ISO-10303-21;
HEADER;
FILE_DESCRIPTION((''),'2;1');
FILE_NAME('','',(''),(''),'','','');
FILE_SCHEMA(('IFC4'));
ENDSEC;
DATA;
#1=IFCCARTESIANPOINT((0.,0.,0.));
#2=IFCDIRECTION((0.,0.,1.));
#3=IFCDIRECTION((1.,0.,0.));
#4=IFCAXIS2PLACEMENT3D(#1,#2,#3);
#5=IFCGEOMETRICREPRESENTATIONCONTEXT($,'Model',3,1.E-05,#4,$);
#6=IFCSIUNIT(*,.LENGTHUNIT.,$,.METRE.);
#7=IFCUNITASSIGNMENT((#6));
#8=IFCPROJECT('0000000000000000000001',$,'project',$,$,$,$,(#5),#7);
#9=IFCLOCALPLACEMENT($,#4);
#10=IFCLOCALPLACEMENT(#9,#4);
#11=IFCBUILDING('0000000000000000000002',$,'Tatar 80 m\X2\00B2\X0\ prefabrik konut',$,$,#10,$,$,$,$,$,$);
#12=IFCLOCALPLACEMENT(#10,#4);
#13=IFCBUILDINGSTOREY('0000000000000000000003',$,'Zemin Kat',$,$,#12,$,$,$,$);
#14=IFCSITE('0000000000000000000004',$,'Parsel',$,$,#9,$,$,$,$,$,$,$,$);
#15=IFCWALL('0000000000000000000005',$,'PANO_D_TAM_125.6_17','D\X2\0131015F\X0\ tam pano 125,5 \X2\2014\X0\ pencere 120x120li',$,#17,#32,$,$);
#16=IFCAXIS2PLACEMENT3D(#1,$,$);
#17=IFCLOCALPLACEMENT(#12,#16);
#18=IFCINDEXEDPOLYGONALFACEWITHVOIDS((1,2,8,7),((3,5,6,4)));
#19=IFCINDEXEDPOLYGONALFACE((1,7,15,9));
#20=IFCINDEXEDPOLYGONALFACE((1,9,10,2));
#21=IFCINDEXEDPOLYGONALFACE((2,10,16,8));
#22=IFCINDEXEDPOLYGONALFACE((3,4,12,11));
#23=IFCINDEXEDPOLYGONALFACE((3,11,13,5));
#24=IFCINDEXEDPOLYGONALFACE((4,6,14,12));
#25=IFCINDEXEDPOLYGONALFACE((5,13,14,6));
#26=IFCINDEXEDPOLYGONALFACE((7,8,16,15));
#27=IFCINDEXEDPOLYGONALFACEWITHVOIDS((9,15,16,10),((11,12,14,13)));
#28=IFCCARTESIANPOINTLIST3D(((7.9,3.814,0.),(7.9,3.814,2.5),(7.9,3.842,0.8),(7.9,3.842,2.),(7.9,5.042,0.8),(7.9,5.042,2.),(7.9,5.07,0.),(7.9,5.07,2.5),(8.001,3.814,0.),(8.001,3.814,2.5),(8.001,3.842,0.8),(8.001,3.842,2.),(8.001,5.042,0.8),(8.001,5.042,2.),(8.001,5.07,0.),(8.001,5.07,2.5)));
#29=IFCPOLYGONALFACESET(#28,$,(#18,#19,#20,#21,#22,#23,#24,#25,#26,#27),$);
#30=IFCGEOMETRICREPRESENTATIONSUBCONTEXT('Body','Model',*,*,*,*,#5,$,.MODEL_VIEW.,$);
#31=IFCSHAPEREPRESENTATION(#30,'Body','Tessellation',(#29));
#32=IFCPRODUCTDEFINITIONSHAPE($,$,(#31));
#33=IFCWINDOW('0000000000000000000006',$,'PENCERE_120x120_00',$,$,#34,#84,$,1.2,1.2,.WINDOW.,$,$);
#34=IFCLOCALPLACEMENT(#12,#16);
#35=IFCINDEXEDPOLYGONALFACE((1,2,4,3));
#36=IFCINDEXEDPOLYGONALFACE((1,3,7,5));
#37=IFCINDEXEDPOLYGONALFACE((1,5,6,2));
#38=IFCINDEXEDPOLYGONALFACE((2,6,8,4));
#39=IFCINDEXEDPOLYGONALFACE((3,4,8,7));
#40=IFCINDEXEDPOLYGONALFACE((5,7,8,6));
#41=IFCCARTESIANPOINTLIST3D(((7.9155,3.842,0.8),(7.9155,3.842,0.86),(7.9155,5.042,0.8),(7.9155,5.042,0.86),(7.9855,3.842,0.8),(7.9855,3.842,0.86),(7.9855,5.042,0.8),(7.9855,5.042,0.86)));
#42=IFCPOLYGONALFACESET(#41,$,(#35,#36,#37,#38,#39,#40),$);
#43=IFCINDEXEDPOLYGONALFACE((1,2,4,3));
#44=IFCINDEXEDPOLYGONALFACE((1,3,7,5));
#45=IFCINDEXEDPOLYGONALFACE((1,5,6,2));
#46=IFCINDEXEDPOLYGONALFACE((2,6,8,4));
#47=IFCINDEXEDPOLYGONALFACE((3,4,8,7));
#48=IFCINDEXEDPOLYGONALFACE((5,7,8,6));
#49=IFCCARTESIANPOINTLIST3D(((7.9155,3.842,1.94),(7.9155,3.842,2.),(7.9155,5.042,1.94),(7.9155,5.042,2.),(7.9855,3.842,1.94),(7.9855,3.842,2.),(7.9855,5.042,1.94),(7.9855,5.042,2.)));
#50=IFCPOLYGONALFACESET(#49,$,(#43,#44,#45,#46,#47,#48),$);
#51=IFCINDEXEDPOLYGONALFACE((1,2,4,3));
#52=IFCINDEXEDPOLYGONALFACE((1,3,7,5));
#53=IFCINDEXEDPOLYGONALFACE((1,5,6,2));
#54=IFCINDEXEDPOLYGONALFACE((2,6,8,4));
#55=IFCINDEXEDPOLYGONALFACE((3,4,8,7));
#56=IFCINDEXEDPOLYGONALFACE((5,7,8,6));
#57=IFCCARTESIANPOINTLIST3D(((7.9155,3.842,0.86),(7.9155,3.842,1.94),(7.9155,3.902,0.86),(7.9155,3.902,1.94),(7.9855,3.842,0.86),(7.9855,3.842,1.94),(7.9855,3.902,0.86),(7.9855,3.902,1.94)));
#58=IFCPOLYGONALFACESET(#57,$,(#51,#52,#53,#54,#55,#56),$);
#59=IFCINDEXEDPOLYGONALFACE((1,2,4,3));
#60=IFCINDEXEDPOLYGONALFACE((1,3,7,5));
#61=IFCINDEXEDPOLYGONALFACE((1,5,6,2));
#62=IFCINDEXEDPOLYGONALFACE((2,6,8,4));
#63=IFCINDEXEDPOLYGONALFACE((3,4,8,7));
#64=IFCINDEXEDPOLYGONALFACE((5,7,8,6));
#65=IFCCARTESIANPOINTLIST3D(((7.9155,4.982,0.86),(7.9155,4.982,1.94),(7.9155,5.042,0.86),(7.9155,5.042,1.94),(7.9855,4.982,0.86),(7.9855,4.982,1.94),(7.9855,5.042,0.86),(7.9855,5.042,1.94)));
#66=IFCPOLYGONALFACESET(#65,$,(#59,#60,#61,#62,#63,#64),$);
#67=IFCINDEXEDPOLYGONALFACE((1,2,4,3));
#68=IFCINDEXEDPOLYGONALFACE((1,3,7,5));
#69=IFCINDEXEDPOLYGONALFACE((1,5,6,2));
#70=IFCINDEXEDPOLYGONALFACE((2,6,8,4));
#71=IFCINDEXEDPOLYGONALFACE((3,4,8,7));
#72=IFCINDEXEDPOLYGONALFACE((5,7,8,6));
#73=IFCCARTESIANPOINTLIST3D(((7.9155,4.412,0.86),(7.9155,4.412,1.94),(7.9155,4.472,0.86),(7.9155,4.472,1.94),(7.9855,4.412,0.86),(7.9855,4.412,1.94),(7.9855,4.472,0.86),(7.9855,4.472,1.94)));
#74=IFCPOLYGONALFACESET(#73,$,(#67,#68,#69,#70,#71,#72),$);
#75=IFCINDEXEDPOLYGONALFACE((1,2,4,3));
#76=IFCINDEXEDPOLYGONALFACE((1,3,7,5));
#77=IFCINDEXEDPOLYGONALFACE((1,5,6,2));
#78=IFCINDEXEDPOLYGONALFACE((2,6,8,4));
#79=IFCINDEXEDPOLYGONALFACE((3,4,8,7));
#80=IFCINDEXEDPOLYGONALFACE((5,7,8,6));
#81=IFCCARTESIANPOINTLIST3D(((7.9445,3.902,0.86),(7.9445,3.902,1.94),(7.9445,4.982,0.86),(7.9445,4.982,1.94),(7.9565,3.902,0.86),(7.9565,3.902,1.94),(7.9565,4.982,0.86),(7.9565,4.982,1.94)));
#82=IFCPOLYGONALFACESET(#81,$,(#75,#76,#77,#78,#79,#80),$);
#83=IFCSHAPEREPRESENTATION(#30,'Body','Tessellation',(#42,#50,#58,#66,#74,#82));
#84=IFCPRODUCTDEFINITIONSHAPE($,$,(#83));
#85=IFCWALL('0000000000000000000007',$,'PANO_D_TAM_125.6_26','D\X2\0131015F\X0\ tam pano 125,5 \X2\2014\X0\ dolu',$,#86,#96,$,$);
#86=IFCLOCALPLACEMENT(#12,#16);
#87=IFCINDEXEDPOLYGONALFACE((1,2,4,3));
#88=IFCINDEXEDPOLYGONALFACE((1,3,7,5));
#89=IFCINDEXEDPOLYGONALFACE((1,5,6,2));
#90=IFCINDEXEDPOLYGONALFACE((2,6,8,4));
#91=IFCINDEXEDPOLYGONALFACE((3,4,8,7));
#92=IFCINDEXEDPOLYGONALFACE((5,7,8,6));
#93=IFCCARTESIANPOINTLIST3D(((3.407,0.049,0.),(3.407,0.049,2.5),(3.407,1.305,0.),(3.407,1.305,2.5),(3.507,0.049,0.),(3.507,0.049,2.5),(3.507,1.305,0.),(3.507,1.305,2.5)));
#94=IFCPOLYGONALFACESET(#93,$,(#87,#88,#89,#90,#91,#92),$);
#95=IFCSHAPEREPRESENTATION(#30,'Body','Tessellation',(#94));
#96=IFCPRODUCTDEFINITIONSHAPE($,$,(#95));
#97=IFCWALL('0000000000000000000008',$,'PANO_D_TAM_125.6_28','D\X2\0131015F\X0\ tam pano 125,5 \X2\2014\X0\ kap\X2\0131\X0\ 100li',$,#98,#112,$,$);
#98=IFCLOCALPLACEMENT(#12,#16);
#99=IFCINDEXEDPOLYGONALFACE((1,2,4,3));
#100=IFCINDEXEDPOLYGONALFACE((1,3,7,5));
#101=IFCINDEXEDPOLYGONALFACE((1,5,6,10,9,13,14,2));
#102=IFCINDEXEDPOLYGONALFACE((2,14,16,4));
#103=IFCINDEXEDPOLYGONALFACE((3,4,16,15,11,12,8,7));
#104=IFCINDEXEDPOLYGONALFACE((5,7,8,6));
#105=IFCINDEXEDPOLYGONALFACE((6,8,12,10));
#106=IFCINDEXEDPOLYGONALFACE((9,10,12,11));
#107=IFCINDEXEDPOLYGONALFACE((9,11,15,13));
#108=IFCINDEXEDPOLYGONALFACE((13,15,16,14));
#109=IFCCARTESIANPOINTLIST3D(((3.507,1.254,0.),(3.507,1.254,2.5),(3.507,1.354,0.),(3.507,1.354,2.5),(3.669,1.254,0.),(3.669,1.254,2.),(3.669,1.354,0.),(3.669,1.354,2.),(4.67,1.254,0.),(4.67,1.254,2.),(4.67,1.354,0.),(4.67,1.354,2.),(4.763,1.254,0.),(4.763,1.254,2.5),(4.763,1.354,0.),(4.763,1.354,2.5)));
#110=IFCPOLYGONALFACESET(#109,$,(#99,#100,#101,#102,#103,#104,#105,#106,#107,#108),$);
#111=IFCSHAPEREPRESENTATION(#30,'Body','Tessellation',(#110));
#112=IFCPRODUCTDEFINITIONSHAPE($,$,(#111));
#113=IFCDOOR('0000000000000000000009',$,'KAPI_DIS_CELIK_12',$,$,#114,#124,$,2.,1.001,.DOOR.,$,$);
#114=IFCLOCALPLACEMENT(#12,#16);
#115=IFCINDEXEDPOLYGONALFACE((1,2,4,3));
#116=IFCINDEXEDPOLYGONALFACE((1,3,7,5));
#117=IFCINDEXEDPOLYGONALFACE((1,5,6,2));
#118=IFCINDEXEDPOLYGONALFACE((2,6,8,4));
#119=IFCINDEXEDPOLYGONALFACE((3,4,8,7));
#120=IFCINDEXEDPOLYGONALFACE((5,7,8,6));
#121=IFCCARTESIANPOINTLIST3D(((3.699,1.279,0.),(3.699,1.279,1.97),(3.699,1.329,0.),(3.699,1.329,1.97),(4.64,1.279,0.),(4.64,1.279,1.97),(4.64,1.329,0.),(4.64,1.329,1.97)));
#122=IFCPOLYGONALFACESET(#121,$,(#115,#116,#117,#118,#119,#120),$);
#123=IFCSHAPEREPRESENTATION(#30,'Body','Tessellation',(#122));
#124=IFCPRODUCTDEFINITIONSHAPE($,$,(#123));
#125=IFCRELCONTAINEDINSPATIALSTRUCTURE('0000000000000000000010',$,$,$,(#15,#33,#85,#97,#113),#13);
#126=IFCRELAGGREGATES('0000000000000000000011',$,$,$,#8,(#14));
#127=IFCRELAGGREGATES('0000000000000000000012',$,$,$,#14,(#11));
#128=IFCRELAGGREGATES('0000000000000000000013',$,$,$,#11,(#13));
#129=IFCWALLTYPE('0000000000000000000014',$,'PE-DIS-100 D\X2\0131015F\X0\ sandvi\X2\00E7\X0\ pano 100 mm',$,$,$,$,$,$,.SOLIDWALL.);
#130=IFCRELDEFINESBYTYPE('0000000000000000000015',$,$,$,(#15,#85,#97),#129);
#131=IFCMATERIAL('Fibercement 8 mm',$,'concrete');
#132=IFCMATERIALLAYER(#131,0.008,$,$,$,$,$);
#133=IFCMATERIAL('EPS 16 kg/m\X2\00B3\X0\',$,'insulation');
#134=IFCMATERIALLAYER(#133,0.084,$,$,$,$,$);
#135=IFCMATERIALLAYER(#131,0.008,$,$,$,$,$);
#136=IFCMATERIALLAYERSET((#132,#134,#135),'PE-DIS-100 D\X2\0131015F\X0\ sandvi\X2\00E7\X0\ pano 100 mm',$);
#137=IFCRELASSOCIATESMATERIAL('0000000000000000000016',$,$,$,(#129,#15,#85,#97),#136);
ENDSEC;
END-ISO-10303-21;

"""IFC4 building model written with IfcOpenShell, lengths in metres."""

from ifc_helpers import new_model, si_unit, frame, origin_with_axes, place, context, subcontext, project, spatial, line, indexed_curve, outline, extrude, material, layer, layer_set, layer_usage, type_object, element, fill, save


model = new_model("IFC4")

# Units and contexts
model_context = context("Model", 3, precision=1e-05, world=origin_with_axes())
body_context = subcontext(model_context, "Body", "Model", "MODEL_VIEW")
ifc_project = project(units=[si_unit("LENGTHUNIT", "METRE")], contexts=[model_context])

# Site, building, storey
site_placement = place(None, origin_with_axes())
site = spatial("IfcSite", under=ifc_project, at=site_placement, Name="Parsel")
building_placement = place(site_placement, origin_with_axes())
building = spatial("IfcBuilding", under=site, at=building_placement, Name="Tatar 80 m² prefabrik konut")
storey_placement = place(building_placement, origin_with_axes())
storey = spatial("IfcBuildingStorey", under=building, at=storey_placement, Name="Zemin Kat")

# Shared definitions
ifc_material_1 = material(Name="Fibercement 8 mm", Category="concrete")
ifc_layer_1 = layer(ifc_material_1, 0.008)
ifc_material_2 = material(Name="EPS 16 kg/m³", Category="insulation")
ifc_layer_2 = layer(ifc_material_2, 0.084)
ifc_layer_3 = layer(ifc_material_1, 0.008)
ifc_layer_set_1 = layer_set([ifc_layer_1, ifc_layer_2, ifc_layer_3], Name="PE-DIS-100 Dış sandviç pano 100 mm")
wall_type_1 = type_object("IfcWallType", Name="PE-DIS-100 Dış sandviç pano 100 mm", PredefinedType="SOLIDWALL", material=ifc_layer_set_1)

# Wall, opening, window
ifc_layer_usage_1 = layer_usage(ifc_layer_set_1, "AXIS2", "POSITIVE", 0.0)
wall_1_placement = place(storey_placement, frame((8.001, 3.814, 0.0), z_axis=(0.0, 0.0, 1.0), x_axis=(0.0, 1.0, 0.0)))
wall_1 = element("IfcWall", 1, at=wall_1_placement, inside=storey, type_object=wall_type_1, material=ifc_layer_usage_1, Name="PANO_D_TAM_125.6_17", Description="Dış tam pano 125,5 — pencere 120x120li", context=body_context, shape_type="SweptSolid", body=[
    extrude(outline(indexed_curve([(0.0, 0.0), (1.256, 0.0), (1.256, 0.101), (0.0, 0.101)], segments=[line(1, 2, 3, 4, 1)])), origin_with_axes(), (0.0, 0.0, 1.0), 2.5),
])
opening_1_placement = place(wall_1_placement, origin_with_axes())
opening_1 = element("IfcOpeningElement", 2, at=opening_1_placement, cuts=wall_1, PredefinedType="OPENING", context=body_context, shape_type="SweptSolid", body=[
    extrude(outline(indexed_curve([(0.0, 0.0), (1.2, 0.0), (1.2, 0.141), (0.0, 0.141)], segments=[line(1, 2, 3, 4, 1)])), frame((0.028, -0.02, 0.8), z_axis=(0.0, 0.0, 1.0), x_axis=(1.0, 0.0, 0.0)), (0.0, 0.0, 1.0), 1.2),
])
window_1_placement = place(storey_placement, frame((8.001, 3.814, 0.0), z_axis=(0.0, 0.0, 1.0), x_axis=(0.0, 1.0, 0.0)))
window_1 = element("IfcWindow", 3, at=window_1_placement, inside=storey, Name="PENCERE_120x120_00", OverallHeight=1.2, OverallWidth=1.2, PredefinedType="WINDOW", context=body_context, shape_type="SweptSolid", body=[
    extrude(outline(indexed_curve([(0.0, 0.0), (1.2, 0.0), (1.2, 0.07), (0.0, 0.07)], segments=[line(1, 2, 3, 4, 1)])), frame((0.028, 0.0155, 0.8), z_axis=(0.0, 0.0, 1.0), x_axis=(1.0, 0.0, 0.0)), (0.0, 0.0, 1.0), 0.06),
    extrude(outline(indexed_curve([(0.0, 0.0), (1.2, 0.0), (1.2, 0.07), (0.0, 0.07)], segments=[line(1, 2, 3, 4, 1)])), frame((0.028, 0.0155, 1.94), z_axis=(0.0, 0.0, 1.0), x_axis=(1.0, 0.0, 0.0)), (0.0, 0.0, 1.0), 0.06),
    extrude(outline(indexed_curve([(0.0, 0.0), (0.06, 0.0), (0.06, 0.07), (0.0, 0.07)], segments=[line(1, 2, 3, 4, 1)])), frame((0.028, 0.0155, 0.86), z_axis=(0.0, 0.0, 1.0), x_axis=(1.0, 0.0, 0.0)), (0.0, 0.0, 1.0), 1.08),
    extrude(outline(indexed_curve([(0.0, 0.0), (0.06, 0.0), (0.06, 0.07), (0.0, 0.07)], segments=[line(1, 2, 3, 4, 1)])), frame((1.168, 0.0155, 0.86), z_axis=(0.0, 0.0, 1.0), x_axis=(1.0, 0.0, 0.0)), (0.0, 0.0, 1.0), 1.08),
    extrude(outline(indexed_curve([(0.0, 0.0), (0.06, 0.0), (0.06, 0.07), (0.0, 0.07)], segments=[line(1, 2, 3, 4, 1)])), frame((0.598, 0.0155, 0.86), z_axis=(0.0, 0.0, 1.0), x_axis=(1.0, 0.0, 0.0)), (0.0, 0.0, 1.0), 1.08),
    extrude(outline(indexed_curve([(0.0, 0.0), (1.08, 0.0), (1.08, 0.012), (0.0, 0.012)], segments=[line(1, 2, 3, 4, 1)])), frame((0.088, 0.0445, 0.86), z_axis=(0.0, 0.0, 1.0), x_axis=(1.0, 0.0, 0.0)), (0.0, 0.0, 1.0), 1.08),
])
fill(opening_1, window_1)

# Wall
ifc_layer_usage_2 = layer_usage(ifc_layer_set_1, "AXIS2", "POSITIVE", 0.0)
wall_2_placement = place(storey_placement, frame((3.507, 0.049, 0.0), z_axis=(0.0, 0.0, 1.0), x_axis=(0.0, 1.0, 0.0)))
element("IfcWall", 4, at=wall_2_placement, inside=storey, type_object=wall_type_1, material=ifc_layer_usage_2, Name="PANO_D_TAM_125.6_26", Description="Dış tam pano 125,5 — dolu", context=body_context, shape_type="SweptSolid", body=[
    extrude(outline(indexed_curve([(0.0, 0.0), (1.256, 0.0), (1.256, 0.1), (0.0, 0.1)], segments=[line(1, 2, 3, 4, 1)])), origin_with_axes(), (0.0, 0.0, 1.0), 2.5),
])

# Wall, opening, door
ifc_layer_usage_3 = layer_usage(ifc_layer_set_1, "AXIS2", "POSITIVE", 0.0)
wall_3_placement = place(storey_placement, frame((3.507, 1.254, 0.0), z_axis=(0.0, 0.0, 1.0), x_axis=(1.0, 0.0, 0.0)))
wall_3 = element("IfcWall", 5, at=wall_3_placement, inside=storey, type_object=wall_type_1, material=ifc_layer_usage_3, Name="PANO_D_TAM_125.6_28", Description="Dış tam pano 125,5 — kapı 100li", context=body_context, shape_type="SweptSolid", body=[
    extrude(outline(indexed_curve([(0.0, 0.0), (1.256, 0.0), (1.256, 0.1), (0.0, 0.1)], segments=[line(1, 2, 3, 4, 1)])), origin_with_axes(), (0.0, 0.0, 1.0), 2.5),
])
opening_2_placement = place(wall_3_placement, origin_with_axes())
opening_2 = element("IfcOpeningElement", 6, at=opening_2_placement, cuts=wall_3, PredefinedType="OPENING", context=body_context, shape_type="SweptSolid", body=[
    extrude(outline(indexed_curve([(0.0, 0.0), (1.001, 0.0), (1.001, 0.14), (0.0, 0.14)], segments=[line(1, 2, 3, 4, 1)])), frame((0.162, -0.02, 0.0), z_axis=(0.0, 0.0, 1.0), x_axis=(1.0, 0.0, 0.0)), (0.0, 0.0, 1.0), 2.0),
])
door_placement = place(storey_placement, frame((3.507, 1.254, 0.0), z_axis=(0.0, 0.0, 1.0), x_axis=(1.0, 0.0, 0.0)))
door = element("IfcDoor", 7, at=door_placement, inside=storey, Name="KAPI_DIS_CELIK_12", OverallHeight=2.0, OverallWidth=1.001, PredefinedType="DOOR", context=body_context, shape_type="SweptSolid", body=[
    extrude(outline(indexed_curve([(0.0, 0.0), (0.941, 0.0), (0.941, 0.05), (0.0, 0.05)], segments=[line(1, 2, 3, 4, 1)])), frame((0.192, 0.025, 0.0), z_axis=(0.0, 0.0, 1.0), x_axis=(1.0, 0.0, 0.0)), (0.0, 0.0, 1.0), 1.97),
])
fill(opening_2, door)

save(model, "model.ifc")
